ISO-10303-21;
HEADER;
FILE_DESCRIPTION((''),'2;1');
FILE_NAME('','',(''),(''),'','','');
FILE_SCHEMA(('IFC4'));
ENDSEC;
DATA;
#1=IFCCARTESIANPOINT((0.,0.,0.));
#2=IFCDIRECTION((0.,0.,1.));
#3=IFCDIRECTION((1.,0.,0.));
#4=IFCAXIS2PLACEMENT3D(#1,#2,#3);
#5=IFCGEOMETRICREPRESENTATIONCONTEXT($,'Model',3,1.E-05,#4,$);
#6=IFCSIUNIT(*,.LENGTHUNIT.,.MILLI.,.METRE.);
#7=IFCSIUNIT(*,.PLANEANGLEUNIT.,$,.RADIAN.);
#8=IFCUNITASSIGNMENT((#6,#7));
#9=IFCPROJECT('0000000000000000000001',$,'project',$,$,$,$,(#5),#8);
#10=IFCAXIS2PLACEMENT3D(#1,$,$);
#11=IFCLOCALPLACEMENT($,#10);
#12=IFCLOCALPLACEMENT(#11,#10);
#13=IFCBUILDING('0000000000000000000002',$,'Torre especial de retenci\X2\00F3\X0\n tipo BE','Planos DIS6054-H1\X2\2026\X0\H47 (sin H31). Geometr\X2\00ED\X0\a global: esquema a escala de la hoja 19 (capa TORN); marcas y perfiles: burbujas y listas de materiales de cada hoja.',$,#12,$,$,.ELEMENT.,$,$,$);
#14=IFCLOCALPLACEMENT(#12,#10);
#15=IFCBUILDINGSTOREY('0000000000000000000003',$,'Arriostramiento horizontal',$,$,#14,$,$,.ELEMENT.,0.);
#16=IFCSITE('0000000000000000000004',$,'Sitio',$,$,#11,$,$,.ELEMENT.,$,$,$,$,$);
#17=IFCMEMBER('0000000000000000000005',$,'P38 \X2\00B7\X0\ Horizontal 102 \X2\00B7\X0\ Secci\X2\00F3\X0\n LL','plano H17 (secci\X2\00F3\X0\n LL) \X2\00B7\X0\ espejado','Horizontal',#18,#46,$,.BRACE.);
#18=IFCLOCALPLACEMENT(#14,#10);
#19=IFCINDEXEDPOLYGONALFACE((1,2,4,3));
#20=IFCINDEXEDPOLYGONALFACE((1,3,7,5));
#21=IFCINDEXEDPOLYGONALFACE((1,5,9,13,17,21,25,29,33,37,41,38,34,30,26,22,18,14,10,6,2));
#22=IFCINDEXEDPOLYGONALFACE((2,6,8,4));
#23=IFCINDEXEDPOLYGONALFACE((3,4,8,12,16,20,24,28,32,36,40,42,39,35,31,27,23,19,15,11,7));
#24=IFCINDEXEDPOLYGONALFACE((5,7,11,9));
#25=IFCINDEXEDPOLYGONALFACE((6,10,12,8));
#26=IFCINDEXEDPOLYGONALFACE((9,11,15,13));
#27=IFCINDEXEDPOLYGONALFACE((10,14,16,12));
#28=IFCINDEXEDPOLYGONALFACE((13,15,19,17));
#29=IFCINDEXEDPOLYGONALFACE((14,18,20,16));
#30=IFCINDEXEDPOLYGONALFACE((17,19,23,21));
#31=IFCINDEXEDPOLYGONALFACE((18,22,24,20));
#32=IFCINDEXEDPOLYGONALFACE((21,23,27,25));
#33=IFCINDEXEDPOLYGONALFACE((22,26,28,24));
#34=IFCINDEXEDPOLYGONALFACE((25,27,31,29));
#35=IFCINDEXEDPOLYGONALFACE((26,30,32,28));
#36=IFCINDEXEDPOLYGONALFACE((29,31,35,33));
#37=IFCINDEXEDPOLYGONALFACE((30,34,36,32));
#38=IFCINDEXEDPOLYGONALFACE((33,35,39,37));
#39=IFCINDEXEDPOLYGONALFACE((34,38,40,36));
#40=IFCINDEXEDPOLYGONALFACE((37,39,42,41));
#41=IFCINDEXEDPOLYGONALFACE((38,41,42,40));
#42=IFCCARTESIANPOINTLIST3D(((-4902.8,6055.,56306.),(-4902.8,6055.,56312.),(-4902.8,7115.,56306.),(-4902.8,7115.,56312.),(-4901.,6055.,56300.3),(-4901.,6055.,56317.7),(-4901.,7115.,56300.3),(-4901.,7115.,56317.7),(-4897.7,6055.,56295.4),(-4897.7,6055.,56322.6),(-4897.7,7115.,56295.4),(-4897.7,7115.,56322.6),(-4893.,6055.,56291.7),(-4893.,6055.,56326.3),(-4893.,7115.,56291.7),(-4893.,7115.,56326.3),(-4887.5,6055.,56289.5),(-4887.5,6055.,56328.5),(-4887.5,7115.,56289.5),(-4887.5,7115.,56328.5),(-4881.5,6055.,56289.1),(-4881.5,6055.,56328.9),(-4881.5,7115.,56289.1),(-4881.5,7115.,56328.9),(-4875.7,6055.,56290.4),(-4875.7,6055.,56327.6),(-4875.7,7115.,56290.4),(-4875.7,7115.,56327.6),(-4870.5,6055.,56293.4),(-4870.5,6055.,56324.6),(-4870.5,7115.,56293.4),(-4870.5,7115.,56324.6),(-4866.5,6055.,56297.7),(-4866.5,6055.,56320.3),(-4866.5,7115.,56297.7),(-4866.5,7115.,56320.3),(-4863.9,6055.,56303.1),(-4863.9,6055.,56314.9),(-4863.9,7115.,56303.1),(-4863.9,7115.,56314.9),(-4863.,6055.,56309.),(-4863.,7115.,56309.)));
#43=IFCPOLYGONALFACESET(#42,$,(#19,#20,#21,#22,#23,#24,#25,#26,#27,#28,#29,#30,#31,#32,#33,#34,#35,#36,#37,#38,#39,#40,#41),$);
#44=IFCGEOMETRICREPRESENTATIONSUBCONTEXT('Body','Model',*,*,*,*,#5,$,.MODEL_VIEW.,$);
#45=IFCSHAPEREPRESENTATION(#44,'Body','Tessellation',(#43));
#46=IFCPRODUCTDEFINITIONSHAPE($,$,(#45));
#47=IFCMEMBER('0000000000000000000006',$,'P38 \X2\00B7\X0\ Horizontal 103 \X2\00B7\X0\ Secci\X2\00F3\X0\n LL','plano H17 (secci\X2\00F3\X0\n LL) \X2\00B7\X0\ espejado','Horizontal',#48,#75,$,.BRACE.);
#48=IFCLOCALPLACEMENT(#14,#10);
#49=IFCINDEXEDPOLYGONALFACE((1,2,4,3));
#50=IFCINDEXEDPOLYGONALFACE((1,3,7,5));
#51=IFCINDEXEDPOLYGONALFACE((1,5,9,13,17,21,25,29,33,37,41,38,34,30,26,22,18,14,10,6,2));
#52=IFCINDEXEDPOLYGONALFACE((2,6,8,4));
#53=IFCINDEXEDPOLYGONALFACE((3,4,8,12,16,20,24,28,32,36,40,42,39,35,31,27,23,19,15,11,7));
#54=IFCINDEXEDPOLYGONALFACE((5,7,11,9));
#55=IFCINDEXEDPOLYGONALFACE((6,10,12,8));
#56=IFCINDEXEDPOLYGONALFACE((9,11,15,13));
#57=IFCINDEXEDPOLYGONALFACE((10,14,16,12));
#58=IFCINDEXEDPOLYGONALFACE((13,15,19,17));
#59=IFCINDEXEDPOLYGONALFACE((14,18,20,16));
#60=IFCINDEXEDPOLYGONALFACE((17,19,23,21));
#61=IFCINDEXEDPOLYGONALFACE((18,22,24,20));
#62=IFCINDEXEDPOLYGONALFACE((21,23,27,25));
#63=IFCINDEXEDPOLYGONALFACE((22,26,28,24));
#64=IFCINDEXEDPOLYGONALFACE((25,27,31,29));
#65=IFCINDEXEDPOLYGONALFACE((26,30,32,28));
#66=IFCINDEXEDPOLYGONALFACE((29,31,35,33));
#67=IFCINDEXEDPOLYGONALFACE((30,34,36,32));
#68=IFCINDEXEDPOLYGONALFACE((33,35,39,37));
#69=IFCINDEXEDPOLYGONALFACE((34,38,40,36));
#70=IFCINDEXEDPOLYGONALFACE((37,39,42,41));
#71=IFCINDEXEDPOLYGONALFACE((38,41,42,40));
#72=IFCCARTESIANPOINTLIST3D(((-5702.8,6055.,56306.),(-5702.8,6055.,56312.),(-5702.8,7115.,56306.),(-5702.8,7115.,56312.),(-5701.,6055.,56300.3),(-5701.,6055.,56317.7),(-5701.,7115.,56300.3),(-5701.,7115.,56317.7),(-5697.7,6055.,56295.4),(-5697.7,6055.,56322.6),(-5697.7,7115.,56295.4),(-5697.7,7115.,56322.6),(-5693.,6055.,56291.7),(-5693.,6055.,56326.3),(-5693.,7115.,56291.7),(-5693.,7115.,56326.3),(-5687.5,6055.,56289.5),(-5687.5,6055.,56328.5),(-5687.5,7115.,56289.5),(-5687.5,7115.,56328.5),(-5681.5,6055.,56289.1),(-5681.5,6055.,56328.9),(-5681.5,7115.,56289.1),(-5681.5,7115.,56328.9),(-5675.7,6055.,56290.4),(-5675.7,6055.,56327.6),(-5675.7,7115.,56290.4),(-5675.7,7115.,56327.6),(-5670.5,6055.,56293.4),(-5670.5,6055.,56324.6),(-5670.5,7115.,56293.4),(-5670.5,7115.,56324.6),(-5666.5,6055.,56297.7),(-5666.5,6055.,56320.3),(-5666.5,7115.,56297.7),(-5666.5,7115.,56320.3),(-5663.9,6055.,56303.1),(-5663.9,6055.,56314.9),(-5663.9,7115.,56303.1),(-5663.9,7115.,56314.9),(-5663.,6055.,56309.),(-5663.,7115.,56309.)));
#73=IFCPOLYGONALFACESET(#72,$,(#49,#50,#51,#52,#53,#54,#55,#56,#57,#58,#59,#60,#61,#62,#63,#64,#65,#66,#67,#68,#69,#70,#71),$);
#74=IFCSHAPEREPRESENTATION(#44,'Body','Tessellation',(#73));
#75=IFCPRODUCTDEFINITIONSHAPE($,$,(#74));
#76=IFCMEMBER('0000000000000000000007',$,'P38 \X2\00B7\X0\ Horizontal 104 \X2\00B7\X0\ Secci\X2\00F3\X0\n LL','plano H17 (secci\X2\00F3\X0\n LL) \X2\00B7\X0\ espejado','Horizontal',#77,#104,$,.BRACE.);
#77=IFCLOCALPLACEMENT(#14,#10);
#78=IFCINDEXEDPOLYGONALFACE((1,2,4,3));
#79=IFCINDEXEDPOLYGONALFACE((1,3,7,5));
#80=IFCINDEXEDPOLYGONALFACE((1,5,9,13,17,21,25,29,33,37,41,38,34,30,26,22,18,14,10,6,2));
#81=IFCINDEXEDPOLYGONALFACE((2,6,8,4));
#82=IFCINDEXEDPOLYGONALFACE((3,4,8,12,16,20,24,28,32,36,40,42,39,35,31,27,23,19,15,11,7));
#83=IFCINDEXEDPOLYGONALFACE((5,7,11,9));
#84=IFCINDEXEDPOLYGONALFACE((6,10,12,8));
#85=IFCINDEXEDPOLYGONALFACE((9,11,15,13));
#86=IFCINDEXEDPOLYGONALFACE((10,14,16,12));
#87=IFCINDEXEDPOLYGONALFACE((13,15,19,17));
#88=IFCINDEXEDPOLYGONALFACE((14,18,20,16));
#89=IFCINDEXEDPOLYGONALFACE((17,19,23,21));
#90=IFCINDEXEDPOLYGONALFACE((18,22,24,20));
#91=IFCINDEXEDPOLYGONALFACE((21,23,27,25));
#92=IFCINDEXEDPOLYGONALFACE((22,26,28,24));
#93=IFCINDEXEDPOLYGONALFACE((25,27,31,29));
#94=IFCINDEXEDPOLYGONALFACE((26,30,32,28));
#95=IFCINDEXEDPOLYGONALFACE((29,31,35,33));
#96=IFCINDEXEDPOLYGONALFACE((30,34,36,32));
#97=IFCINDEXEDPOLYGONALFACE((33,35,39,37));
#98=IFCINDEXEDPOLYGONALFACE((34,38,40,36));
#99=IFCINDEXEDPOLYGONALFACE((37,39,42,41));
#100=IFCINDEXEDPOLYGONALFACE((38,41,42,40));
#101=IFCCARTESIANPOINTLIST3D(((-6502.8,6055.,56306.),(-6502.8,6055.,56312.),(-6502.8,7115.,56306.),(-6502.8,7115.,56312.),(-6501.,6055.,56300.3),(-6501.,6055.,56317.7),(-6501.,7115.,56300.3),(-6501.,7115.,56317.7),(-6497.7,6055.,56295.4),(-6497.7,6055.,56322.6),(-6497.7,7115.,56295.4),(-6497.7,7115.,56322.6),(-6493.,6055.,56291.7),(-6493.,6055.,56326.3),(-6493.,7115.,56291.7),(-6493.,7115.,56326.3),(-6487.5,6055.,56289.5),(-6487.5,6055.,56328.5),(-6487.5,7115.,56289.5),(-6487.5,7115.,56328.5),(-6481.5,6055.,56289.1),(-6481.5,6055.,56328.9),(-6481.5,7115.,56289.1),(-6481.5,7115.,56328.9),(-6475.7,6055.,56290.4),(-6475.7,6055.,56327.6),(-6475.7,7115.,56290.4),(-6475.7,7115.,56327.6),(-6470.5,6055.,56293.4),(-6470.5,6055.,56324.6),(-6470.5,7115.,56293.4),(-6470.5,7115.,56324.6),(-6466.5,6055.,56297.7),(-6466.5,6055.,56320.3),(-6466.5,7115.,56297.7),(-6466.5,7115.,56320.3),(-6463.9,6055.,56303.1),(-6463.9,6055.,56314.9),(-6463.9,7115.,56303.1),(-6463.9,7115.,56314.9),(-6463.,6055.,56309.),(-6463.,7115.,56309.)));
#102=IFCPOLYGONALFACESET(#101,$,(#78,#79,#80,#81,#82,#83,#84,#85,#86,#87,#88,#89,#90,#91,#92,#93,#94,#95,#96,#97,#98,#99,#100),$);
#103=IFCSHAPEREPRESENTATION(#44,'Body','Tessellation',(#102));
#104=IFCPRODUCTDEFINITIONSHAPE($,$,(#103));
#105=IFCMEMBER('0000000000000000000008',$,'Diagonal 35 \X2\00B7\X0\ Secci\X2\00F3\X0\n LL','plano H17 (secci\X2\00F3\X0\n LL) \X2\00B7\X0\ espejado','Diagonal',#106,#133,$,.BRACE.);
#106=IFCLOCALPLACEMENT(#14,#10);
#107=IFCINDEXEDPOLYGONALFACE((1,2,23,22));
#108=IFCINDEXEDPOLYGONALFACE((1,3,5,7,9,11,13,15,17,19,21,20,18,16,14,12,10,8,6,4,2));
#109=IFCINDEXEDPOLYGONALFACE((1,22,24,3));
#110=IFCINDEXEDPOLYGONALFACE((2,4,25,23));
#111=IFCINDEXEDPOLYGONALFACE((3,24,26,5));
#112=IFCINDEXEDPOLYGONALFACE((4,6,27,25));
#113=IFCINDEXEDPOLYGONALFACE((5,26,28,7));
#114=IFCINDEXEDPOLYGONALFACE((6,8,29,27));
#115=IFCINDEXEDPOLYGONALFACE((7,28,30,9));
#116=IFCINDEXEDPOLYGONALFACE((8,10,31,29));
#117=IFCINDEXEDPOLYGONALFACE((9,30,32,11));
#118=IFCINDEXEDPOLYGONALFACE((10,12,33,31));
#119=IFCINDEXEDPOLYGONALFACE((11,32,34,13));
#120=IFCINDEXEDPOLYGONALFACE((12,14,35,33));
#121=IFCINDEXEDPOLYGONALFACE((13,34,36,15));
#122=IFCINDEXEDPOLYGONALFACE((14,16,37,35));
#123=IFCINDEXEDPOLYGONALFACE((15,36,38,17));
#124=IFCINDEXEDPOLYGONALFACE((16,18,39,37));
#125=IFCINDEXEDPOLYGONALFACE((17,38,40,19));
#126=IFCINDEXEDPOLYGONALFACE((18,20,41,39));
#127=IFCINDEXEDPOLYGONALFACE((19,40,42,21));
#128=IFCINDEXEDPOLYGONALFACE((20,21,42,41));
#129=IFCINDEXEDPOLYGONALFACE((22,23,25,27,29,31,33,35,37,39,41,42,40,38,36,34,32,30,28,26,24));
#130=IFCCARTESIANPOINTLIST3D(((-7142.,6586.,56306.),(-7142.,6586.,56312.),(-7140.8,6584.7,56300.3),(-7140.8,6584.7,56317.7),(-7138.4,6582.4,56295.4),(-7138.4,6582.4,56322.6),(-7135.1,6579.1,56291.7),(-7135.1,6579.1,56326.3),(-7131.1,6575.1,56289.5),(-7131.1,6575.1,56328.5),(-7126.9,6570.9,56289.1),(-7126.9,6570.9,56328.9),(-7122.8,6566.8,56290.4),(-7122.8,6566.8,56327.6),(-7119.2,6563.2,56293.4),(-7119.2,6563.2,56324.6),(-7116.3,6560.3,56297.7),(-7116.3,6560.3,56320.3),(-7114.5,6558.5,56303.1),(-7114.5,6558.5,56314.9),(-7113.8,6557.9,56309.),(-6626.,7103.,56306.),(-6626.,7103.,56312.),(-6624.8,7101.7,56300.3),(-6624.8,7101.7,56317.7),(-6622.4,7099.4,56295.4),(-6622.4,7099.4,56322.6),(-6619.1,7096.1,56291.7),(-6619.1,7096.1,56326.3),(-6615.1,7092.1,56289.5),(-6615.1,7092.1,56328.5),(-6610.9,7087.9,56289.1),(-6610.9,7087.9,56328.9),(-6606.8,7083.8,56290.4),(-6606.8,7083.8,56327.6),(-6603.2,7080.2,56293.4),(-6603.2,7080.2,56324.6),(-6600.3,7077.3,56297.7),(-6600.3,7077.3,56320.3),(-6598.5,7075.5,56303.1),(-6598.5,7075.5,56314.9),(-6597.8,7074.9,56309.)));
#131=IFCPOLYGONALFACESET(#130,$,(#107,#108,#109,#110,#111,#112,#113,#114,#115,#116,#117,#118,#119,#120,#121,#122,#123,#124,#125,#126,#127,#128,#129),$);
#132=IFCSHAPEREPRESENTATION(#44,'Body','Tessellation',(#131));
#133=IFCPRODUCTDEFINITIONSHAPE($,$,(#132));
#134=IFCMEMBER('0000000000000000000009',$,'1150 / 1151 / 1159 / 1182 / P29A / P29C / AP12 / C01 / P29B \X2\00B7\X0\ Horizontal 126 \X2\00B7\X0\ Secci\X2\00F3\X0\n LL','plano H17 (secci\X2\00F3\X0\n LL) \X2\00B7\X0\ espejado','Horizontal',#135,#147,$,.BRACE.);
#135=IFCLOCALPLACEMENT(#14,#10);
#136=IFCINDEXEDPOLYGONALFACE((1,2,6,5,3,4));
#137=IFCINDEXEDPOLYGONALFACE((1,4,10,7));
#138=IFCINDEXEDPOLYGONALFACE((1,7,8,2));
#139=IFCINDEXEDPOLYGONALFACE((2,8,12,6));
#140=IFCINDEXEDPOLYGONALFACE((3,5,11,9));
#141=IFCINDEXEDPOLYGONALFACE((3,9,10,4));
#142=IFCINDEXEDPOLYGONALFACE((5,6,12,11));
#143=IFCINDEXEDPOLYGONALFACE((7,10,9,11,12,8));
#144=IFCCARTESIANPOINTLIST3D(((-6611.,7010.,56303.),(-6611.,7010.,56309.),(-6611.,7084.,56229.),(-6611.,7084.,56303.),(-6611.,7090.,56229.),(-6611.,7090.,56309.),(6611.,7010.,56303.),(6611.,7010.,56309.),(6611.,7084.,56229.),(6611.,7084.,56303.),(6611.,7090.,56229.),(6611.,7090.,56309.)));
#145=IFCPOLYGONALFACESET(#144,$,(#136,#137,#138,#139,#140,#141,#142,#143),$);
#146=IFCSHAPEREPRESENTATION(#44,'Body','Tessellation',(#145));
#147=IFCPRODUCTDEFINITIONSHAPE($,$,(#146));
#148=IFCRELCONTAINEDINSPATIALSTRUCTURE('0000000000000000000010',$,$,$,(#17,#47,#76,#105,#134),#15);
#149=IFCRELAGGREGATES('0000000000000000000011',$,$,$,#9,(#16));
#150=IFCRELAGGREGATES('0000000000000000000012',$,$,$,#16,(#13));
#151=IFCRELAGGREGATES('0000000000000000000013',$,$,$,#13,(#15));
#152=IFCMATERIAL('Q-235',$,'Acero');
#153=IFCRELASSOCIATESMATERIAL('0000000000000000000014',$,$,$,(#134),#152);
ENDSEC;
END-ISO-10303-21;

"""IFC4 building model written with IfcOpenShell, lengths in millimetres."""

from ifc_helpers import new_model, si_unit, frame, frame_2d, origin, origin_with_axes, place, context, subcontext, project, spatial, circle, l_section, extrude, material, element, save


model = new_model("IFC4")

# Units and contexts
model_context = context("Model", 3, precision=1e-05, world=origin_with_axes())
body_context = subcontext(model_context, "Body", "Model", "MODEL_VIEW")
ifc_project = project(units=[si_unit("LENGTHUNIT", "METRE", prefix="MILLI"), si_unit("PLANEANGLEUNIT", "RADIAN")], contexts=[model_context])

# Site, building, storey
site_placement = place(None, origin())
site = spatial("IfcSite", under=ifc_project, at=site_placement, Name="Sitio", CompositionType="ELEMENT")
building_placement = place(site_placement, origin())
building = spatial("IfcBuilding", under=site, at=building_placement, Name="Torre especial de retención tipo BE", Description="Planos DIS6054-H1…H47 (sin H31). Geometría global: esquema a escala de la hoja 19 (capa TORN); marcas y perfiles: burbujas y listas de materiales de cada hoja.", CompositionType="ELEMENT")
storey_placement = place(building_placement, origin())
storey = spatial("IfcBuildingStorey", under=building, at=storey_placement, Name="Arriostramiento horizontal", CompositionType="ELEMENT", Elevation=0.0)

# Members
ifc_material = material(Name="Q-235", Category="Acero")
for number, where, z_axis, x_axis, name in (
    (1, (-4883.0, 7115.0, 56309.0), (0.0, -1.0, 0.0), (1.0, 0.0, 0.0), "P38 · Horizontal 102 · Sección LL"),
    (2, (-5683.0, 7115.0, 56309.0), (0.0, -1.0, 0.0), (1.0, 0.0, 0.0), "P38 · Horizontal 103 · Sección LL"),
    (3, (-6483.0, 7115.0, 56309.0), (0.0, -1.0, 0.0), (1.0, 0.0, 0.0), "P38 · Horizontal 104 · Sección LL"),
):
    element("IfcMember", number, at=place(storey_placement, frame(where, z_axis=z_axis, x_axis=x_axis)), inside=storey, Name=name, Description="plano H17 (sección LL) · espejado", ObjectType="Horizontal", PredefinedType="BRACE", context=body_context, shape_type="SweptSolid", body=[
        extrude(circle(Radius=20.0), None, (0.0, 0.0, 1.0), 1060.0),
    ])
member_1_placement = place(storey_placement, frame((-6612.0, 7089.0, 56309.0), z_axis=(-0.706422, -0.707791, 0.0), x_axis=(0.707791, -0.706422, 0.0)))
element("IfcMember", 4, at=member_1_placement, inside=storey, Name="Diagonal 35 · Sección LL", Description="plano H17 (sección LL) · espejado", ObjectType="Diagonal", PredefinedType="BRACE", context=body_context, shape_type="SweptSolid", body=[
    extrude(circle(Radius=20.0), None, (0.0, 0.0, 1.0), 730.4),
])
member_2_placement = place(storey_placement, frame((-6611.0, 7090.0, 56309.0), z_axis=(1.0, 0.0, 0.0), x_axis=(0.0, -1.0, 0.0)))
element("IfcMember", 5, at=member_2_placement, inside=storey, material=ifc_material, Name="1150 / 1151 / 1159 / 1182 / P29A / P29C / AP12 / C01 / P29B · Horizontal 126 · Sección LL", Description="plano H17 (sección LL) · espejado", ObjectType="Horizontal", PredefinedType="BRACE", context=body_context, shape_type="SweptSolid", body=[
    extrude(l_section(Depth=80.0, Width=80.0, Thickness=6.0, at=frame_2d((40.0, 40.0))), None, (0.0, 0.0, 1.0), 13222.0),
])

save(model, "model.ifc")
